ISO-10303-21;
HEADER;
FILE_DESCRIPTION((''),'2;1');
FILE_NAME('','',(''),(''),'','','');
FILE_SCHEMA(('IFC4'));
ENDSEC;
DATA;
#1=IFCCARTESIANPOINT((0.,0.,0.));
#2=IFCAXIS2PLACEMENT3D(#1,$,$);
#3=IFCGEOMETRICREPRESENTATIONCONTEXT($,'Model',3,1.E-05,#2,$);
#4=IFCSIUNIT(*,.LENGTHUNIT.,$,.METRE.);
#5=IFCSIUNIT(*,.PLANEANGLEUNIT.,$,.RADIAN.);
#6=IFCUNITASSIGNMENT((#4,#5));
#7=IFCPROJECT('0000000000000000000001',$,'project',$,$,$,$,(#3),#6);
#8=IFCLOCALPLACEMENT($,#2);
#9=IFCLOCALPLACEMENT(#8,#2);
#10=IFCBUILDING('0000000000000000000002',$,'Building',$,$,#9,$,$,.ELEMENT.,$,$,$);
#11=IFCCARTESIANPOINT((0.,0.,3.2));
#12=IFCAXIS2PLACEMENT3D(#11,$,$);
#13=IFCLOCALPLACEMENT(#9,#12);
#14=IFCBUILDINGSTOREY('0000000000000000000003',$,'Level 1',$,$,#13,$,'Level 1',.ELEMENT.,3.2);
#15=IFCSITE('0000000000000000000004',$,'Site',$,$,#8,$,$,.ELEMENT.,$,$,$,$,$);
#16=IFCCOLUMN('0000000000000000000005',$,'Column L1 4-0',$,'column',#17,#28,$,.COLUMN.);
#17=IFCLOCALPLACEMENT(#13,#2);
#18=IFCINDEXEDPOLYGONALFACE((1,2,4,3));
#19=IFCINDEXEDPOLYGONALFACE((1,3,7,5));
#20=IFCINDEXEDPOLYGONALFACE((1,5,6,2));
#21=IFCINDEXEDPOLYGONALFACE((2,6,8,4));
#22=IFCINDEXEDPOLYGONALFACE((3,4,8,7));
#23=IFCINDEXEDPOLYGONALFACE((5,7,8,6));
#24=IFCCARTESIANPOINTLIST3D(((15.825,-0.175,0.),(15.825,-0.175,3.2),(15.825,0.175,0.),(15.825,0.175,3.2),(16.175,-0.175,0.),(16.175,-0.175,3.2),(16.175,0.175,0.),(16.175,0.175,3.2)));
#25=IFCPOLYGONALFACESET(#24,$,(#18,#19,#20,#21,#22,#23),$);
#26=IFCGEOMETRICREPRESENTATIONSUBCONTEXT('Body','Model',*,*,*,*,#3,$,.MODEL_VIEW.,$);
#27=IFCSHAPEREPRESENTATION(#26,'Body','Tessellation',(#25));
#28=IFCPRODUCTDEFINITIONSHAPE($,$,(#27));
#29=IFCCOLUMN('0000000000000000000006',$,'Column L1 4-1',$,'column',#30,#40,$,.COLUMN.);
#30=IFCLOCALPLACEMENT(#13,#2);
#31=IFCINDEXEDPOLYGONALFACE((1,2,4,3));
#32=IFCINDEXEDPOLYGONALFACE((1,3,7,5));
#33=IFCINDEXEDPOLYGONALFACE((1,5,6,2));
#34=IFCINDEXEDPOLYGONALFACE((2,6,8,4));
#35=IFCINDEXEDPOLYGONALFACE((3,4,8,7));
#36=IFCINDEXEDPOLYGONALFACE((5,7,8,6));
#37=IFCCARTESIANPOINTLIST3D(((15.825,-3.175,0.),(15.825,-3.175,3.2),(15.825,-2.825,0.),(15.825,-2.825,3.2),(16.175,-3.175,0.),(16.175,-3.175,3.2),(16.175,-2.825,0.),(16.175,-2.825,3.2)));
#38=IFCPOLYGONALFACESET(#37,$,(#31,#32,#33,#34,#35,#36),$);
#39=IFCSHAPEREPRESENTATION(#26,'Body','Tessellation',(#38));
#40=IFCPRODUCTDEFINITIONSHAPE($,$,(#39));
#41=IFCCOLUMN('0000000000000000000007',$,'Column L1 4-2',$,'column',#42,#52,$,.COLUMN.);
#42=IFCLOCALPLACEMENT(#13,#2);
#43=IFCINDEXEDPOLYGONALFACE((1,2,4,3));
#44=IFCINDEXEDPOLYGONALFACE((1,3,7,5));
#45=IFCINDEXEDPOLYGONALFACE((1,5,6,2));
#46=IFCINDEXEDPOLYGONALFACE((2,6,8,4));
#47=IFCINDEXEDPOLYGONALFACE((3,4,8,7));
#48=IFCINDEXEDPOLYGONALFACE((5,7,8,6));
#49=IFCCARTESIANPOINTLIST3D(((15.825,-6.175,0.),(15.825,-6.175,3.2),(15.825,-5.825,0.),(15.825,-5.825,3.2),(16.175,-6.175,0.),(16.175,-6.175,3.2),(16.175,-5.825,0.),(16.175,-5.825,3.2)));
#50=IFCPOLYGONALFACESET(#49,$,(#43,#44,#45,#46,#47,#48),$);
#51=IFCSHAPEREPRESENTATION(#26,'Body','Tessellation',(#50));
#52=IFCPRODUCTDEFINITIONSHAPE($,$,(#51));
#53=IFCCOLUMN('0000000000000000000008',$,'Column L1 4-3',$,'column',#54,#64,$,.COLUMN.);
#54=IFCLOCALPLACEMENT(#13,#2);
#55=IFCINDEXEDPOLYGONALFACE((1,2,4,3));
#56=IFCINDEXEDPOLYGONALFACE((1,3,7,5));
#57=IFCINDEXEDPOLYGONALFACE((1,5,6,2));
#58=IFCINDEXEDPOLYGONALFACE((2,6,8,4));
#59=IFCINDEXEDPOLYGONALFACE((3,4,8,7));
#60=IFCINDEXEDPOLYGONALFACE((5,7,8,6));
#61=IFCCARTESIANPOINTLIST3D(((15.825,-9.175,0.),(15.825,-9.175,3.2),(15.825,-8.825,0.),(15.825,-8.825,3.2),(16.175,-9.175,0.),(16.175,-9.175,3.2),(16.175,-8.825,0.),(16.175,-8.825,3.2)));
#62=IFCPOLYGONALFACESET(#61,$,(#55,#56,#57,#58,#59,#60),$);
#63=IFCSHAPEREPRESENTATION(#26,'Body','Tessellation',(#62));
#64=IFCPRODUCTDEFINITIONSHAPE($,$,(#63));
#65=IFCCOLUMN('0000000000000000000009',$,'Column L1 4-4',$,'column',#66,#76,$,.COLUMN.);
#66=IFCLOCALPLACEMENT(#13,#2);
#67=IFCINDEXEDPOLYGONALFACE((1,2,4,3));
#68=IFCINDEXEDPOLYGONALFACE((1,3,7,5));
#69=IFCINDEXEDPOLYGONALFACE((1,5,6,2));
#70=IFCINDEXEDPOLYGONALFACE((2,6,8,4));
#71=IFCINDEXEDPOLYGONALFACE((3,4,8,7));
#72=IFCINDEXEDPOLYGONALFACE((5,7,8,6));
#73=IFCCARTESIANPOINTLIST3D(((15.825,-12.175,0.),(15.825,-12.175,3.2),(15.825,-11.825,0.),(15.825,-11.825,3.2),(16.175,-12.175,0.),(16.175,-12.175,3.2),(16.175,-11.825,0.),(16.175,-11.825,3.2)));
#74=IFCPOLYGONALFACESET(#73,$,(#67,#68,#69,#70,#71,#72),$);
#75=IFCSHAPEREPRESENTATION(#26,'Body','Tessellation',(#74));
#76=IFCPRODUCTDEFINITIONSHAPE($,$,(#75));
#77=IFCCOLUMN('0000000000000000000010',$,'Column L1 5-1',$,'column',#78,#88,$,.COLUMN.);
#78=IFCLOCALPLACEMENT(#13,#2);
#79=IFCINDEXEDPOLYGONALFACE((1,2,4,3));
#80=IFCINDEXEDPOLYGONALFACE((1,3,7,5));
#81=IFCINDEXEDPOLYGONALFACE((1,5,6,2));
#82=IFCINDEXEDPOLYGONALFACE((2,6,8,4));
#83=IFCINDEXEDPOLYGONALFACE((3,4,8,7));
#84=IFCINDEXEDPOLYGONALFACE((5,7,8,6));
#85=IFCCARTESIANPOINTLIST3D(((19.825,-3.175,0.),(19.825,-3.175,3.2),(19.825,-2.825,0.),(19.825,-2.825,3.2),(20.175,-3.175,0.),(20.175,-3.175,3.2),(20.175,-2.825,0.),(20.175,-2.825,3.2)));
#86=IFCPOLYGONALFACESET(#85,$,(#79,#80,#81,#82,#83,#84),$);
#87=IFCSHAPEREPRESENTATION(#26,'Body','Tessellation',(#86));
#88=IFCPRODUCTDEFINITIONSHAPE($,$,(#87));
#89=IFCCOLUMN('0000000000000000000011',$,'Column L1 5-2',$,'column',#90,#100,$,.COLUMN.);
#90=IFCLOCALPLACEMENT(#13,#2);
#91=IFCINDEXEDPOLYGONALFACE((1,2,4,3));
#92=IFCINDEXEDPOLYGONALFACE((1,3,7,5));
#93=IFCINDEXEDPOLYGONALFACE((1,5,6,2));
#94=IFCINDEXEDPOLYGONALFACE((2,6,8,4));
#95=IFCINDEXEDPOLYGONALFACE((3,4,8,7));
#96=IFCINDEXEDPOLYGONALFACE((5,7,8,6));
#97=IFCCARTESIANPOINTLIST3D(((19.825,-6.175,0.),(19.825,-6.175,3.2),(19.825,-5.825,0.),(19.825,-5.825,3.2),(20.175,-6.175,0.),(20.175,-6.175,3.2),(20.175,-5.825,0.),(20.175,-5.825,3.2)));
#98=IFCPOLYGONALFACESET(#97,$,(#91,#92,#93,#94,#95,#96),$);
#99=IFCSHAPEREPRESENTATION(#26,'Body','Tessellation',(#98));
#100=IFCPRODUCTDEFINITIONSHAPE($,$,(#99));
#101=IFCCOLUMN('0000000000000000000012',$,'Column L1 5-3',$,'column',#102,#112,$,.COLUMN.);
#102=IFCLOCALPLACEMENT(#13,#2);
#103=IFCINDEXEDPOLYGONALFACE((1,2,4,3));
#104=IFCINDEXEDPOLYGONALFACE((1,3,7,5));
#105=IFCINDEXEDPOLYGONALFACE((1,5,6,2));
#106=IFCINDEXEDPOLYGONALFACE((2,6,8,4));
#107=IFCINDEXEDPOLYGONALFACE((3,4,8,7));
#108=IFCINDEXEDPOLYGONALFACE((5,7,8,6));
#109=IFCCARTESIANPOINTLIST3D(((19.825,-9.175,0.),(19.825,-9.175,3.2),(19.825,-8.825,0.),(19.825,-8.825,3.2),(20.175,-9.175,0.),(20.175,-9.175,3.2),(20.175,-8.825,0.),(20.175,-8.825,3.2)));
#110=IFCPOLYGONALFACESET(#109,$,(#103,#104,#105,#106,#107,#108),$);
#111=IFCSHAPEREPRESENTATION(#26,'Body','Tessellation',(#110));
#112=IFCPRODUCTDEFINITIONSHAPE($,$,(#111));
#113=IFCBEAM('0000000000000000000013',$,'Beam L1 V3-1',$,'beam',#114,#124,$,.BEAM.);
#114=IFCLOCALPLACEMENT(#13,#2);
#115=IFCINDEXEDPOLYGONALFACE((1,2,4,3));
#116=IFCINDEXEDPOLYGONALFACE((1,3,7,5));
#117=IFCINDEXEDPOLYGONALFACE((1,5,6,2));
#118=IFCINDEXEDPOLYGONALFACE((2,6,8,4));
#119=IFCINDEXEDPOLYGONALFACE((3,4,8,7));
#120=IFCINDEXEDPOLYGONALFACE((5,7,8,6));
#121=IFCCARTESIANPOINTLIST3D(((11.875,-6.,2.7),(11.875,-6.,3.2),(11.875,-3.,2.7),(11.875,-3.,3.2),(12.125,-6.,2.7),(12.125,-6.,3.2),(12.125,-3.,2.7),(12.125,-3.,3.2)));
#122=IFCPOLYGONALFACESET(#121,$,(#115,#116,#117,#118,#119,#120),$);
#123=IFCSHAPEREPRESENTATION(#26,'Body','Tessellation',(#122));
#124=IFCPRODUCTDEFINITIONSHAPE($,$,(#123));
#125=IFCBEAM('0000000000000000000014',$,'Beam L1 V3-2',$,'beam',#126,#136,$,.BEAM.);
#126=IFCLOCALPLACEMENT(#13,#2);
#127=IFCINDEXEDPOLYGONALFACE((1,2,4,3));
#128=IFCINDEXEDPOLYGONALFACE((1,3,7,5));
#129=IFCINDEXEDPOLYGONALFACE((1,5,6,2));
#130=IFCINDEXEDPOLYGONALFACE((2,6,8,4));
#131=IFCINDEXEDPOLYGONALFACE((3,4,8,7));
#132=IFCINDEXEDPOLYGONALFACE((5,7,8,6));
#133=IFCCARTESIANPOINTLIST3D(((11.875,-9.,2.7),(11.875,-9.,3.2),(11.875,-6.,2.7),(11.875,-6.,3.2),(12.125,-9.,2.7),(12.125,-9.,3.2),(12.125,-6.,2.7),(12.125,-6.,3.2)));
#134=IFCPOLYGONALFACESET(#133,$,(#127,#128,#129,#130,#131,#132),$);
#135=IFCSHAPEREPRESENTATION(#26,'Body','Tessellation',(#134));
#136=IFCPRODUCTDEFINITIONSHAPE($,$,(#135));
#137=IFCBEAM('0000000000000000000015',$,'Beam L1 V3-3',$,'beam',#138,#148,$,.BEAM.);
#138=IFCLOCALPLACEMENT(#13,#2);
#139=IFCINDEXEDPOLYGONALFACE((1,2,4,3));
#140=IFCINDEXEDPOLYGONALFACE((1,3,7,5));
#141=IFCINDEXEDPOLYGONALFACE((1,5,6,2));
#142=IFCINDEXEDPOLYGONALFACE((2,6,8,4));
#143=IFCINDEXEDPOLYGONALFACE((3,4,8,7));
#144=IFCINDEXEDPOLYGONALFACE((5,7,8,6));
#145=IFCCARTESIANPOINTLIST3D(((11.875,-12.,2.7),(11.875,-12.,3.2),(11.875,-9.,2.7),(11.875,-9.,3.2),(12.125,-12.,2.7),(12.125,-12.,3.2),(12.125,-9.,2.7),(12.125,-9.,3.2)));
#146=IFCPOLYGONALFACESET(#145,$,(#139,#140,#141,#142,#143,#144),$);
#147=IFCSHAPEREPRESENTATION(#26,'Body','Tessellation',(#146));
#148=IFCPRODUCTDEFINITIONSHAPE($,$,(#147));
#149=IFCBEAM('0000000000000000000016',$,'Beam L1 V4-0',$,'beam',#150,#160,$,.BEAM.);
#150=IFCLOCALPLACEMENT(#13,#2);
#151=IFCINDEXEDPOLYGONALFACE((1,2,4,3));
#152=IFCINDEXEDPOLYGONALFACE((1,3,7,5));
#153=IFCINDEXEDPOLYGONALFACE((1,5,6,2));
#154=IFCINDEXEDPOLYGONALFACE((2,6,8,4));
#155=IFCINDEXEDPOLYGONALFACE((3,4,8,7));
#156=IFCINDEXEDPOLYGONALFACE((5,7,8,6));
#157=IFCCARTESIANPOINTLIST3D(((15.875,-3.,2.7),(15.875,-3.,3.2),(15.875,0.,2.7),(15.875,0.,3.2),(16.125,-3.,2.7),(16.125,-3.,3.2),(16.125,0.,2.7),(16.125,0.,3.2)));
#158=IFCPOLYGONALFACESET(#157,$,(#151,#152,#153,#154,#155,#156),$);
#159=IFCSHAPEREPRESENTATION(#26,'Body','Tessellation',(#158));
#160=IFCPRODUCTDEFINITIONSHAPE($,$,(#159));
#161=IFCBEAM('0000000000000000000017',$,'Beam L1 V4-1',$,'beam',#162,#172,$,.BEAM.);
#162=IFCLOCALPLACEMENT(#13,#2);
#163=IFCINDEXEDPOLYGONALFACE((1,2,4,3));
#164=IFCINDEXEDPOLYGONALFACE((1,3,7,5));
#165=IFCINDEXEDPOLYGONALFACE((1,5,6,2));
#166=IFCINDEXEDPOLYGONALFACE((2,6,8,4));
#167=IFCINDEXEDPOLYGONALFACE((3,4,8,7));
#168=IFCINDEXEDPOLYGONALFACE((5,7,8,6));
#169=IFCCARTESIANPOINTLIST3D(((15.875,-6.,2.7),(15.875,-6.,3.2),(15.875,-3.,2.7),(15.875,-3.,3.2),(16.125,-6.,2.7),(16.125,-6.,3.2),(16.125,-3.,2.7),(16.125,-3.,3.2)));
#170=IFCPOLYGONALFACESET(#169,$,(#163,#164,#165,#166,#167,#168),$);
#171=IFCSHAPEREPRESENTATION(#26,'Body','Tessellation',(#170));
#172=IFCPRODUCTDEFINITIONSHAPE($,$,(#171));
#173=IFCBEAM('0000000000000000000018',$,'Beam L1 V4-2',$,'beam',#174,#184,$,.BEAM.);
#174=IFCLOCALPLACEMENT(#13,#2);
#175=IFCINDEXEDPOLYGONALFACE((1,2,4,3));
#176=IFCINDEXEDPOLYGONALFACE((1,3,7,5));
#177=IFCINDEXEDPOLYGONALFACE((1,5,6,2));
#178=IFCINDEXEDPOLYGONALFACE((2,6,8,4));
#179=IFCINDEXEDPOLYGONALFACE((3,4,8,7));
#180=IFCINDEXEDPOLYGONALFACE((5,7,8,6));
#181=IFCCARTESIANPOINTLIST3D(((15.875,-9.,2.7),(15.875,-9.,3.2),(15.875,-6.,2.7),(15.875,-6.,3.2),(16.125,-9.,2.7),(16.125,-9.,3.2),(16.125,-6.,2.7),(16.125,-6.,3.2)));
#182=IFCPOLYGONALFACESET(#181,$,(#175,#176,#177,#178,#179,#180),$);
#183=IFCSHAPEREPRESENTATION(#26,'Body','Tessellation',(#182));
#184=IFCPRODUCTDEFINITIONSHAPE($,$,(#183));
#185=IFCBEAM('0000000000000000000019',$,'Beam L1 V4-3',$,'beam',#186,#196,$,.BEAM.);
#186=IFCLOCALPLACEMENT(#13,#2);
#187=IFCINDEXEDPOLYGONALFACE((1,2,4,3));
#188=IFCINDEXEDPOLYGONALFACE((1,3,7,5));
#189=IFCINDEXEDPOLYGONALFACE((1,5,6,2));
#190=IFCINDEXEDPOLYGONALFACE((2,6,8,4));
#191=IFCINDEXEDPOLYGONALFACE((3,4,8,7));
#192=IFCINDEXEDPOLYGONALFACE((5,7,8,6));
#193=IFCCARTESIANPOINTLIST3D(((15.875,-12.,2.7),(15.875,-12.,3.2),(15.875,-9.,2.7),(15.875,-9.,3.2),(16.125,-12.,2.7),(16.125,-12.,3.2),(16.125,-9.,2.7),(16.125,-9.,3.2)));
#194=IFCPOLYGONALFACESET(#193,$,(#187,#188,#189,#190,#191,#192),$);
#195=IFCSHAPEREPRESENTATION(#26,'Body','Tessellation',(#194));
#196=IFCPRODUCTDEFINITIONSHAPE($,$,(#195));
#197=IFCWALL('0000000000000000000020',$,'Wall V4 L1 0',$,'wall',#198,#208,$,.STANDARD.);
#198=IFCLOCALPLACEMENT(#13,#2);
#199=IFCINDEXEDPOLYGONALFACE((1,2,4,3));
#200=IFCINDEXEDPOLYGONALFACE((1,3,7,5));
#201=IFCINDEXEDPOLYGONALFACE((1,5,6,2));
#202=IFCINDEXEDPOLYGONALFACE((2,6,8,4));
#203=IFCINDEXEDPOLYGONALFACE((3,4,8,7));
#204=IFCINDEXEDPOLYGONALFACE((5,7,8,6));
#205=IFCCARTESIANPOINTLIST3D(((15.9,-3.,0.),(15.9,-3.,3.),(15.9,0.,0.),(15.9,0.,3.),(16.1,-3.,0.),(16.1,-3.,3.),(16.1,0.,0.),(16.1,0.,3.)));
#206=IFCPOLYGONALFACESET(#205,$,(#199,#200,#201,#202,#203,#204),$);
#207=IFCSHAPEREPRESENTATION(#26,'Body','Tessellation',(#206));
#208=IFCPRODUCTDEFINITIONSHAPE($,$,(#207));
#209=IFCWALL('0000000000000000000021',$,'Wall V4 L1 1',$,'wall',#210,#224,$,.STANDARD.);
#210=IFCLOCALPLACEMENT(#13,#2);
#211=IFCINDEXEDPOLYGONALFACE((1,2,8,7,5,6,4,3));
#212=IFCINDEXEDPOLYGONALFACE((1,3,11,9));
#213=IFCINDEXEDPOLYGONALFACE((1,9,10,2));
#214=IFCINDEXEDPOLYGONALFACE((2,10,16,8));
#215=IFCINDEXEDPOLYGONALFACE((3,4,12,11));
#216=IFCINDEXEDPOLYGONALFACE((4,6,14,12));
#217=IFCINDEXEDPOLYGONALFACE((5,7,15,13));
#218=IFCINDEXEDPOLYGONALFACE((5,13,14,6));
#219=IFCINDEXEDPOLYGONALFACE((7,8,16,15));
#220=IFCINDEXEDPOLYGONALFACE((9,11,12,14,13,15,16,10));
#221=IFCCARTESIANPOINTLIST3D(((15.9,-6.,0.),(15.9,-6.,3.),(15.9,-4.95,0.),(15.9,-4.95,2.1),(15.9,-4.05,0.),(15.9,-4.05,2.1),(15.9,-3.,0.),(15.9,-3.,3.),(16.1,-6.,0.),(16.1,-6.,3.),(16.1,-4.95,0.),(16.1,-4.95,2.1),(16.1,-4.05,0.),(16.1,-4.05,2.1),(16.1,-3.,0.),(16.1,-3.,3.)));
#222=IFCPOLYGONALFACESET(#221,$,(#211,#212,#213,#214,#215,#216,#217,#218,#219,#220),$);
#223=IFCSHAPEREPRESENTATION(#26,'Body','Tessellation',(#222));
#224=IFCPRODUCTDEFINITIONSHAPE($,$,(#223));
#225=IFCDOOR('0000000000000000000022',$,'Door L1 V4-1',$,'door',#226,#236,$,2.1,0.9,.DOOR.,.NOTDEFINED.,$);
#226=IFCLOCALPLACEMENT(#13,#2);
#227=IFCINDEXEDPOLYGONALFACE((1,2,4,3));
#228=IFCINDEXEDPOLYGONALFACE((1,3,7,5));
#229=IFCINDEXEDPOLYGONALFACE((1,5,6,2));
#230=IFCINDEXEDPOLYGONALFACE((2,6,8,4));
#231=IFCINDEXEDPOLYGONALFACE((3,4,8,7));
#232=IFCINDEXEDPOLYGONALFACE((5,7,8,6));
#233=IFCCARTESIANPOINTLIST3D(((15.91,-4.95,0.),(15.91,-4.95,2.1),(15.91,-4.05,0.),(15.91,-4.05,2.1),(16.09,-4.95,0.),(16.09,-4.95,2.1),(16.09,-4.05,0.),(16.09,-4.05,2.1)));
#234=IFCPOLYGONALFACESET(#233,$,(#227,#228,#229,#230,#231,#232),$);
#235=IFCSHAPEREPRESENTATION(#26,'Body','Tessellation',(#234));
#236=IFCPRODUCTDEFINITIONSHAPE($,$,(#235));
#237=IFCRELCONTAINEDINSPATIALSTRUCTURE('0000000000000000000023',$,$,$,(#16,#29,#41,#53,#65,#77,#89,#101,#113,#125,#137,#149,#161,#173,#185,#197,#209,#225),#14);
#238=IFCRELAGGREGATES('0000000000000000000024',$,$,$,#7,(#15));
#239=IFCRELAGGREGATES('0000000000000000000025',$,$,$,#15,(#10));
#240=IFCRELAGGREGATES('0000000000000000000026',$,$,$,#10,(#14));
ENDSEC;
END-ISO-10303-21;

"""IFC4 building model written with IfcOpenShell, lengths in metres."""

from ifc_helpers import new_model, si_unit, frame, frame_2d, origin, origin_2d, place, context, subcontext, project, spatial, rectangle, extrude, element, fill, save


model = new_model("IFC4")

# Units and contexts
model_context = context("Model", 3, precision=1e-05, world=origin())
body_context = subcontext(model_context, "Body", "Model", "MODEL_VIEW")
ifc_project = project(units=[si_unit("LENGTHUNIT", "METRE"), si_unit("PLANEANGLEUNIT", "RADIAN")], contexts=[model_context])

# Site, building, storey
site_placement = place(None, origin())
site = spatial("IfcSite", under=ifc_project, at=site_placement, Name="Site", CompositionType="ELEMENT")
building_placement = place(site_placement, origin())
building = spatial("IfcBuilding", under=site, at=building_placement, Name="Building", CompositionType="ELEMENT")
storey_placement = place(building_placement, frame((0.0, 0.0, 3.2)))
storey = spatial("IfcBuildingStorey", under=building, at=storey_placement, Name="Level 1", LongName="Level 1", CompositionType="ELEMENT", Elevation=3.2)

# Columns
for number, where, name in (
    (1, (16.0, 0.0, 0.0), "Column L1 4-0"),
    (2, (16.0, -3.0, 0.0), "Column L1 4-1"),
    (3, (16.0, -6.0, 0.0), "Column L1 4-2"),
    (4, (16.0, -9.0, 0.0), "Column L1 4-3"),
    (5, (16.0, -12.0, 0.0), "Column L1 4-4"),
    (6, (20.0, -3.0, 0.0), "Column L1 5-1"),
    (7, (20.0, -6.0, 0.0), "Column L1 5-2"),
    (8, (20.0, -9.0, 0.0), "Column L1 5-3"),
):
    element("IfcColumn", number, at=place(storey_placement, frame(where)), inside=storey, Name=name, ObjectType="column", PredefinedType="COLUMN", context=body_context, shape_type="SweptSolid", body=[
        extrude(rectangle(XDim=0.35, YDim=0.35, at=origin_2d()), origin(), (0.0, 0.0, 1.0), 3.2),
    ])

# Beams
for number, where, z_axis, x_axis, name in (
    (9, (12.0, -3.0, 2.95), (0.0, -1.0, 0.0), (0.0, 0.0, 1.0), "Beam L1 V3-1"),
    (10, (12.0, -6.0, 2.95), (0.0, -1.0, 0.0), (0.0, 0.0, 1.0), "Beam L1 V3-2"),
    (11, (12.0, -9.0, 2.95), (0.0, -1.0, 0.0), (0.0, 0.0, 1.0), "Beam L1 V3-3"),
    (12, (16.0, 0.0, 2.95), (0.0, -1.0, 0.0), (0.0, 0.0, 1.0), "Beam L1 V4-0"),
    (13, (16.0, -3.0, 2.95), (0.0, -1.0, 0.0), (0.0, 0.0, 1.0), "Beam L1 V4-1"),
    (14, (16.0, -6.0, 2.95), (0.0, -1.0, 0.0), (0.0, 0.0, 1.0), "Beam L1 V4-2"),
    (15, (16.0, -9.0, 2.95), (0.0, -1.0, 0.0), (0.0, 0.0, 1.0), "Beam L1 V4-3"),
):
    element("IfcBeam", number, at=place(storey_placement, frame(where, z_axis=z_axis, x_axis=x_axis)), inside=storey, Name=name, ObjectType="beam", PredefinedType="BEAM", context=body_context, shape_type="SweptSolid", body=[
        extrude(rectangle(XDim=0.5, YDim=0.25, at=origin_2d()), origin(), (0.0, 0.0, 1.0), 3.0),
    ])

# Wall
wall_1_placement = place(storey_placement, frame((16.0, 0.0, 0.0), z_axis=(0.0, 0.0, 1.0), x_axis=(0.0, -1.0, 0.0)))
element("IfcWall", 16, at=wall_1_placement, inside=storey, Name="Wall V4 L1 0", ObjectType="wall", PredefinedType="STANDARD", context=body_context, shape_type="SweptSolid", body=[
    extrude(rectangle(XDim=3.0, YDim=0.2, at=frame_2d((1.5, 0.0))), origin(), (0.0, 0.0, 1.0), 3.0),
])

# Wall, opening, door
wall_2_placement = place(storey_placement, frame((16.0, -3.0, 0.0), z_axis=(0.0, 0.0, 1.0), x_axis=(0.0, -1.0, 0.0)))
wall_2 = element("IfcWall", 17, at=wall_2_placement, inside=storey, Name="Wall V4 L1 1", ObjectType="wall", PredefinedType="STANDARD", context=body_context, shape_type="SweptSolid", body=[
    extrude(rectangle(XDim=3.0, YDim=0.2, at=frame_2d((1.5, 0.0))), origin(), (0.0, 0.0, 1.0), 3.0),
])
opening_1_placement = place(storey_placement, frame((16.0, -4.5, 0.0), z_axis=(0.0, 0.0, 1.0), x_axis=(0.0, -1.0, 0.0)))
opening_1 = element("IfcOpeningElement", 18, at=opening_1_placement, cuts=wall_2, ObjectType="Opening", PredefinedType="OPENING", context=body_context, shape_type="SweptSolid", body=[
    extrude(rectangle(XDim=0.9, YDim=0.22, at=origin_2d()), origin(), (0.0, 0.0, 1.0), 2.1),
])
door_placement = place(storey_placement, frame((16.0, -4.5, 0.0), z_axis=(0.0, 0.0, 1.0), x_axis=(0.0, -1.0, 0.0)))
door = element("IfcDoor", 19, at=door_placement, inside=storey, Name="Door L1 V4-1", ObjectType="door", OperationType="NOTDEFINED", OverallHeight=2.1, OverallWidth=0.9, PredefinedType="DOOR", context=body_context, shape_type="SweptSolid", body=[
    extrude(rectangle(XDim=0.9, YDim=0.18, at=origin_2d()), origin(), (0.0, 0.0, 1.0), 2.1),
])
fill(opening_1, door)

save(model, "model.ifc")
